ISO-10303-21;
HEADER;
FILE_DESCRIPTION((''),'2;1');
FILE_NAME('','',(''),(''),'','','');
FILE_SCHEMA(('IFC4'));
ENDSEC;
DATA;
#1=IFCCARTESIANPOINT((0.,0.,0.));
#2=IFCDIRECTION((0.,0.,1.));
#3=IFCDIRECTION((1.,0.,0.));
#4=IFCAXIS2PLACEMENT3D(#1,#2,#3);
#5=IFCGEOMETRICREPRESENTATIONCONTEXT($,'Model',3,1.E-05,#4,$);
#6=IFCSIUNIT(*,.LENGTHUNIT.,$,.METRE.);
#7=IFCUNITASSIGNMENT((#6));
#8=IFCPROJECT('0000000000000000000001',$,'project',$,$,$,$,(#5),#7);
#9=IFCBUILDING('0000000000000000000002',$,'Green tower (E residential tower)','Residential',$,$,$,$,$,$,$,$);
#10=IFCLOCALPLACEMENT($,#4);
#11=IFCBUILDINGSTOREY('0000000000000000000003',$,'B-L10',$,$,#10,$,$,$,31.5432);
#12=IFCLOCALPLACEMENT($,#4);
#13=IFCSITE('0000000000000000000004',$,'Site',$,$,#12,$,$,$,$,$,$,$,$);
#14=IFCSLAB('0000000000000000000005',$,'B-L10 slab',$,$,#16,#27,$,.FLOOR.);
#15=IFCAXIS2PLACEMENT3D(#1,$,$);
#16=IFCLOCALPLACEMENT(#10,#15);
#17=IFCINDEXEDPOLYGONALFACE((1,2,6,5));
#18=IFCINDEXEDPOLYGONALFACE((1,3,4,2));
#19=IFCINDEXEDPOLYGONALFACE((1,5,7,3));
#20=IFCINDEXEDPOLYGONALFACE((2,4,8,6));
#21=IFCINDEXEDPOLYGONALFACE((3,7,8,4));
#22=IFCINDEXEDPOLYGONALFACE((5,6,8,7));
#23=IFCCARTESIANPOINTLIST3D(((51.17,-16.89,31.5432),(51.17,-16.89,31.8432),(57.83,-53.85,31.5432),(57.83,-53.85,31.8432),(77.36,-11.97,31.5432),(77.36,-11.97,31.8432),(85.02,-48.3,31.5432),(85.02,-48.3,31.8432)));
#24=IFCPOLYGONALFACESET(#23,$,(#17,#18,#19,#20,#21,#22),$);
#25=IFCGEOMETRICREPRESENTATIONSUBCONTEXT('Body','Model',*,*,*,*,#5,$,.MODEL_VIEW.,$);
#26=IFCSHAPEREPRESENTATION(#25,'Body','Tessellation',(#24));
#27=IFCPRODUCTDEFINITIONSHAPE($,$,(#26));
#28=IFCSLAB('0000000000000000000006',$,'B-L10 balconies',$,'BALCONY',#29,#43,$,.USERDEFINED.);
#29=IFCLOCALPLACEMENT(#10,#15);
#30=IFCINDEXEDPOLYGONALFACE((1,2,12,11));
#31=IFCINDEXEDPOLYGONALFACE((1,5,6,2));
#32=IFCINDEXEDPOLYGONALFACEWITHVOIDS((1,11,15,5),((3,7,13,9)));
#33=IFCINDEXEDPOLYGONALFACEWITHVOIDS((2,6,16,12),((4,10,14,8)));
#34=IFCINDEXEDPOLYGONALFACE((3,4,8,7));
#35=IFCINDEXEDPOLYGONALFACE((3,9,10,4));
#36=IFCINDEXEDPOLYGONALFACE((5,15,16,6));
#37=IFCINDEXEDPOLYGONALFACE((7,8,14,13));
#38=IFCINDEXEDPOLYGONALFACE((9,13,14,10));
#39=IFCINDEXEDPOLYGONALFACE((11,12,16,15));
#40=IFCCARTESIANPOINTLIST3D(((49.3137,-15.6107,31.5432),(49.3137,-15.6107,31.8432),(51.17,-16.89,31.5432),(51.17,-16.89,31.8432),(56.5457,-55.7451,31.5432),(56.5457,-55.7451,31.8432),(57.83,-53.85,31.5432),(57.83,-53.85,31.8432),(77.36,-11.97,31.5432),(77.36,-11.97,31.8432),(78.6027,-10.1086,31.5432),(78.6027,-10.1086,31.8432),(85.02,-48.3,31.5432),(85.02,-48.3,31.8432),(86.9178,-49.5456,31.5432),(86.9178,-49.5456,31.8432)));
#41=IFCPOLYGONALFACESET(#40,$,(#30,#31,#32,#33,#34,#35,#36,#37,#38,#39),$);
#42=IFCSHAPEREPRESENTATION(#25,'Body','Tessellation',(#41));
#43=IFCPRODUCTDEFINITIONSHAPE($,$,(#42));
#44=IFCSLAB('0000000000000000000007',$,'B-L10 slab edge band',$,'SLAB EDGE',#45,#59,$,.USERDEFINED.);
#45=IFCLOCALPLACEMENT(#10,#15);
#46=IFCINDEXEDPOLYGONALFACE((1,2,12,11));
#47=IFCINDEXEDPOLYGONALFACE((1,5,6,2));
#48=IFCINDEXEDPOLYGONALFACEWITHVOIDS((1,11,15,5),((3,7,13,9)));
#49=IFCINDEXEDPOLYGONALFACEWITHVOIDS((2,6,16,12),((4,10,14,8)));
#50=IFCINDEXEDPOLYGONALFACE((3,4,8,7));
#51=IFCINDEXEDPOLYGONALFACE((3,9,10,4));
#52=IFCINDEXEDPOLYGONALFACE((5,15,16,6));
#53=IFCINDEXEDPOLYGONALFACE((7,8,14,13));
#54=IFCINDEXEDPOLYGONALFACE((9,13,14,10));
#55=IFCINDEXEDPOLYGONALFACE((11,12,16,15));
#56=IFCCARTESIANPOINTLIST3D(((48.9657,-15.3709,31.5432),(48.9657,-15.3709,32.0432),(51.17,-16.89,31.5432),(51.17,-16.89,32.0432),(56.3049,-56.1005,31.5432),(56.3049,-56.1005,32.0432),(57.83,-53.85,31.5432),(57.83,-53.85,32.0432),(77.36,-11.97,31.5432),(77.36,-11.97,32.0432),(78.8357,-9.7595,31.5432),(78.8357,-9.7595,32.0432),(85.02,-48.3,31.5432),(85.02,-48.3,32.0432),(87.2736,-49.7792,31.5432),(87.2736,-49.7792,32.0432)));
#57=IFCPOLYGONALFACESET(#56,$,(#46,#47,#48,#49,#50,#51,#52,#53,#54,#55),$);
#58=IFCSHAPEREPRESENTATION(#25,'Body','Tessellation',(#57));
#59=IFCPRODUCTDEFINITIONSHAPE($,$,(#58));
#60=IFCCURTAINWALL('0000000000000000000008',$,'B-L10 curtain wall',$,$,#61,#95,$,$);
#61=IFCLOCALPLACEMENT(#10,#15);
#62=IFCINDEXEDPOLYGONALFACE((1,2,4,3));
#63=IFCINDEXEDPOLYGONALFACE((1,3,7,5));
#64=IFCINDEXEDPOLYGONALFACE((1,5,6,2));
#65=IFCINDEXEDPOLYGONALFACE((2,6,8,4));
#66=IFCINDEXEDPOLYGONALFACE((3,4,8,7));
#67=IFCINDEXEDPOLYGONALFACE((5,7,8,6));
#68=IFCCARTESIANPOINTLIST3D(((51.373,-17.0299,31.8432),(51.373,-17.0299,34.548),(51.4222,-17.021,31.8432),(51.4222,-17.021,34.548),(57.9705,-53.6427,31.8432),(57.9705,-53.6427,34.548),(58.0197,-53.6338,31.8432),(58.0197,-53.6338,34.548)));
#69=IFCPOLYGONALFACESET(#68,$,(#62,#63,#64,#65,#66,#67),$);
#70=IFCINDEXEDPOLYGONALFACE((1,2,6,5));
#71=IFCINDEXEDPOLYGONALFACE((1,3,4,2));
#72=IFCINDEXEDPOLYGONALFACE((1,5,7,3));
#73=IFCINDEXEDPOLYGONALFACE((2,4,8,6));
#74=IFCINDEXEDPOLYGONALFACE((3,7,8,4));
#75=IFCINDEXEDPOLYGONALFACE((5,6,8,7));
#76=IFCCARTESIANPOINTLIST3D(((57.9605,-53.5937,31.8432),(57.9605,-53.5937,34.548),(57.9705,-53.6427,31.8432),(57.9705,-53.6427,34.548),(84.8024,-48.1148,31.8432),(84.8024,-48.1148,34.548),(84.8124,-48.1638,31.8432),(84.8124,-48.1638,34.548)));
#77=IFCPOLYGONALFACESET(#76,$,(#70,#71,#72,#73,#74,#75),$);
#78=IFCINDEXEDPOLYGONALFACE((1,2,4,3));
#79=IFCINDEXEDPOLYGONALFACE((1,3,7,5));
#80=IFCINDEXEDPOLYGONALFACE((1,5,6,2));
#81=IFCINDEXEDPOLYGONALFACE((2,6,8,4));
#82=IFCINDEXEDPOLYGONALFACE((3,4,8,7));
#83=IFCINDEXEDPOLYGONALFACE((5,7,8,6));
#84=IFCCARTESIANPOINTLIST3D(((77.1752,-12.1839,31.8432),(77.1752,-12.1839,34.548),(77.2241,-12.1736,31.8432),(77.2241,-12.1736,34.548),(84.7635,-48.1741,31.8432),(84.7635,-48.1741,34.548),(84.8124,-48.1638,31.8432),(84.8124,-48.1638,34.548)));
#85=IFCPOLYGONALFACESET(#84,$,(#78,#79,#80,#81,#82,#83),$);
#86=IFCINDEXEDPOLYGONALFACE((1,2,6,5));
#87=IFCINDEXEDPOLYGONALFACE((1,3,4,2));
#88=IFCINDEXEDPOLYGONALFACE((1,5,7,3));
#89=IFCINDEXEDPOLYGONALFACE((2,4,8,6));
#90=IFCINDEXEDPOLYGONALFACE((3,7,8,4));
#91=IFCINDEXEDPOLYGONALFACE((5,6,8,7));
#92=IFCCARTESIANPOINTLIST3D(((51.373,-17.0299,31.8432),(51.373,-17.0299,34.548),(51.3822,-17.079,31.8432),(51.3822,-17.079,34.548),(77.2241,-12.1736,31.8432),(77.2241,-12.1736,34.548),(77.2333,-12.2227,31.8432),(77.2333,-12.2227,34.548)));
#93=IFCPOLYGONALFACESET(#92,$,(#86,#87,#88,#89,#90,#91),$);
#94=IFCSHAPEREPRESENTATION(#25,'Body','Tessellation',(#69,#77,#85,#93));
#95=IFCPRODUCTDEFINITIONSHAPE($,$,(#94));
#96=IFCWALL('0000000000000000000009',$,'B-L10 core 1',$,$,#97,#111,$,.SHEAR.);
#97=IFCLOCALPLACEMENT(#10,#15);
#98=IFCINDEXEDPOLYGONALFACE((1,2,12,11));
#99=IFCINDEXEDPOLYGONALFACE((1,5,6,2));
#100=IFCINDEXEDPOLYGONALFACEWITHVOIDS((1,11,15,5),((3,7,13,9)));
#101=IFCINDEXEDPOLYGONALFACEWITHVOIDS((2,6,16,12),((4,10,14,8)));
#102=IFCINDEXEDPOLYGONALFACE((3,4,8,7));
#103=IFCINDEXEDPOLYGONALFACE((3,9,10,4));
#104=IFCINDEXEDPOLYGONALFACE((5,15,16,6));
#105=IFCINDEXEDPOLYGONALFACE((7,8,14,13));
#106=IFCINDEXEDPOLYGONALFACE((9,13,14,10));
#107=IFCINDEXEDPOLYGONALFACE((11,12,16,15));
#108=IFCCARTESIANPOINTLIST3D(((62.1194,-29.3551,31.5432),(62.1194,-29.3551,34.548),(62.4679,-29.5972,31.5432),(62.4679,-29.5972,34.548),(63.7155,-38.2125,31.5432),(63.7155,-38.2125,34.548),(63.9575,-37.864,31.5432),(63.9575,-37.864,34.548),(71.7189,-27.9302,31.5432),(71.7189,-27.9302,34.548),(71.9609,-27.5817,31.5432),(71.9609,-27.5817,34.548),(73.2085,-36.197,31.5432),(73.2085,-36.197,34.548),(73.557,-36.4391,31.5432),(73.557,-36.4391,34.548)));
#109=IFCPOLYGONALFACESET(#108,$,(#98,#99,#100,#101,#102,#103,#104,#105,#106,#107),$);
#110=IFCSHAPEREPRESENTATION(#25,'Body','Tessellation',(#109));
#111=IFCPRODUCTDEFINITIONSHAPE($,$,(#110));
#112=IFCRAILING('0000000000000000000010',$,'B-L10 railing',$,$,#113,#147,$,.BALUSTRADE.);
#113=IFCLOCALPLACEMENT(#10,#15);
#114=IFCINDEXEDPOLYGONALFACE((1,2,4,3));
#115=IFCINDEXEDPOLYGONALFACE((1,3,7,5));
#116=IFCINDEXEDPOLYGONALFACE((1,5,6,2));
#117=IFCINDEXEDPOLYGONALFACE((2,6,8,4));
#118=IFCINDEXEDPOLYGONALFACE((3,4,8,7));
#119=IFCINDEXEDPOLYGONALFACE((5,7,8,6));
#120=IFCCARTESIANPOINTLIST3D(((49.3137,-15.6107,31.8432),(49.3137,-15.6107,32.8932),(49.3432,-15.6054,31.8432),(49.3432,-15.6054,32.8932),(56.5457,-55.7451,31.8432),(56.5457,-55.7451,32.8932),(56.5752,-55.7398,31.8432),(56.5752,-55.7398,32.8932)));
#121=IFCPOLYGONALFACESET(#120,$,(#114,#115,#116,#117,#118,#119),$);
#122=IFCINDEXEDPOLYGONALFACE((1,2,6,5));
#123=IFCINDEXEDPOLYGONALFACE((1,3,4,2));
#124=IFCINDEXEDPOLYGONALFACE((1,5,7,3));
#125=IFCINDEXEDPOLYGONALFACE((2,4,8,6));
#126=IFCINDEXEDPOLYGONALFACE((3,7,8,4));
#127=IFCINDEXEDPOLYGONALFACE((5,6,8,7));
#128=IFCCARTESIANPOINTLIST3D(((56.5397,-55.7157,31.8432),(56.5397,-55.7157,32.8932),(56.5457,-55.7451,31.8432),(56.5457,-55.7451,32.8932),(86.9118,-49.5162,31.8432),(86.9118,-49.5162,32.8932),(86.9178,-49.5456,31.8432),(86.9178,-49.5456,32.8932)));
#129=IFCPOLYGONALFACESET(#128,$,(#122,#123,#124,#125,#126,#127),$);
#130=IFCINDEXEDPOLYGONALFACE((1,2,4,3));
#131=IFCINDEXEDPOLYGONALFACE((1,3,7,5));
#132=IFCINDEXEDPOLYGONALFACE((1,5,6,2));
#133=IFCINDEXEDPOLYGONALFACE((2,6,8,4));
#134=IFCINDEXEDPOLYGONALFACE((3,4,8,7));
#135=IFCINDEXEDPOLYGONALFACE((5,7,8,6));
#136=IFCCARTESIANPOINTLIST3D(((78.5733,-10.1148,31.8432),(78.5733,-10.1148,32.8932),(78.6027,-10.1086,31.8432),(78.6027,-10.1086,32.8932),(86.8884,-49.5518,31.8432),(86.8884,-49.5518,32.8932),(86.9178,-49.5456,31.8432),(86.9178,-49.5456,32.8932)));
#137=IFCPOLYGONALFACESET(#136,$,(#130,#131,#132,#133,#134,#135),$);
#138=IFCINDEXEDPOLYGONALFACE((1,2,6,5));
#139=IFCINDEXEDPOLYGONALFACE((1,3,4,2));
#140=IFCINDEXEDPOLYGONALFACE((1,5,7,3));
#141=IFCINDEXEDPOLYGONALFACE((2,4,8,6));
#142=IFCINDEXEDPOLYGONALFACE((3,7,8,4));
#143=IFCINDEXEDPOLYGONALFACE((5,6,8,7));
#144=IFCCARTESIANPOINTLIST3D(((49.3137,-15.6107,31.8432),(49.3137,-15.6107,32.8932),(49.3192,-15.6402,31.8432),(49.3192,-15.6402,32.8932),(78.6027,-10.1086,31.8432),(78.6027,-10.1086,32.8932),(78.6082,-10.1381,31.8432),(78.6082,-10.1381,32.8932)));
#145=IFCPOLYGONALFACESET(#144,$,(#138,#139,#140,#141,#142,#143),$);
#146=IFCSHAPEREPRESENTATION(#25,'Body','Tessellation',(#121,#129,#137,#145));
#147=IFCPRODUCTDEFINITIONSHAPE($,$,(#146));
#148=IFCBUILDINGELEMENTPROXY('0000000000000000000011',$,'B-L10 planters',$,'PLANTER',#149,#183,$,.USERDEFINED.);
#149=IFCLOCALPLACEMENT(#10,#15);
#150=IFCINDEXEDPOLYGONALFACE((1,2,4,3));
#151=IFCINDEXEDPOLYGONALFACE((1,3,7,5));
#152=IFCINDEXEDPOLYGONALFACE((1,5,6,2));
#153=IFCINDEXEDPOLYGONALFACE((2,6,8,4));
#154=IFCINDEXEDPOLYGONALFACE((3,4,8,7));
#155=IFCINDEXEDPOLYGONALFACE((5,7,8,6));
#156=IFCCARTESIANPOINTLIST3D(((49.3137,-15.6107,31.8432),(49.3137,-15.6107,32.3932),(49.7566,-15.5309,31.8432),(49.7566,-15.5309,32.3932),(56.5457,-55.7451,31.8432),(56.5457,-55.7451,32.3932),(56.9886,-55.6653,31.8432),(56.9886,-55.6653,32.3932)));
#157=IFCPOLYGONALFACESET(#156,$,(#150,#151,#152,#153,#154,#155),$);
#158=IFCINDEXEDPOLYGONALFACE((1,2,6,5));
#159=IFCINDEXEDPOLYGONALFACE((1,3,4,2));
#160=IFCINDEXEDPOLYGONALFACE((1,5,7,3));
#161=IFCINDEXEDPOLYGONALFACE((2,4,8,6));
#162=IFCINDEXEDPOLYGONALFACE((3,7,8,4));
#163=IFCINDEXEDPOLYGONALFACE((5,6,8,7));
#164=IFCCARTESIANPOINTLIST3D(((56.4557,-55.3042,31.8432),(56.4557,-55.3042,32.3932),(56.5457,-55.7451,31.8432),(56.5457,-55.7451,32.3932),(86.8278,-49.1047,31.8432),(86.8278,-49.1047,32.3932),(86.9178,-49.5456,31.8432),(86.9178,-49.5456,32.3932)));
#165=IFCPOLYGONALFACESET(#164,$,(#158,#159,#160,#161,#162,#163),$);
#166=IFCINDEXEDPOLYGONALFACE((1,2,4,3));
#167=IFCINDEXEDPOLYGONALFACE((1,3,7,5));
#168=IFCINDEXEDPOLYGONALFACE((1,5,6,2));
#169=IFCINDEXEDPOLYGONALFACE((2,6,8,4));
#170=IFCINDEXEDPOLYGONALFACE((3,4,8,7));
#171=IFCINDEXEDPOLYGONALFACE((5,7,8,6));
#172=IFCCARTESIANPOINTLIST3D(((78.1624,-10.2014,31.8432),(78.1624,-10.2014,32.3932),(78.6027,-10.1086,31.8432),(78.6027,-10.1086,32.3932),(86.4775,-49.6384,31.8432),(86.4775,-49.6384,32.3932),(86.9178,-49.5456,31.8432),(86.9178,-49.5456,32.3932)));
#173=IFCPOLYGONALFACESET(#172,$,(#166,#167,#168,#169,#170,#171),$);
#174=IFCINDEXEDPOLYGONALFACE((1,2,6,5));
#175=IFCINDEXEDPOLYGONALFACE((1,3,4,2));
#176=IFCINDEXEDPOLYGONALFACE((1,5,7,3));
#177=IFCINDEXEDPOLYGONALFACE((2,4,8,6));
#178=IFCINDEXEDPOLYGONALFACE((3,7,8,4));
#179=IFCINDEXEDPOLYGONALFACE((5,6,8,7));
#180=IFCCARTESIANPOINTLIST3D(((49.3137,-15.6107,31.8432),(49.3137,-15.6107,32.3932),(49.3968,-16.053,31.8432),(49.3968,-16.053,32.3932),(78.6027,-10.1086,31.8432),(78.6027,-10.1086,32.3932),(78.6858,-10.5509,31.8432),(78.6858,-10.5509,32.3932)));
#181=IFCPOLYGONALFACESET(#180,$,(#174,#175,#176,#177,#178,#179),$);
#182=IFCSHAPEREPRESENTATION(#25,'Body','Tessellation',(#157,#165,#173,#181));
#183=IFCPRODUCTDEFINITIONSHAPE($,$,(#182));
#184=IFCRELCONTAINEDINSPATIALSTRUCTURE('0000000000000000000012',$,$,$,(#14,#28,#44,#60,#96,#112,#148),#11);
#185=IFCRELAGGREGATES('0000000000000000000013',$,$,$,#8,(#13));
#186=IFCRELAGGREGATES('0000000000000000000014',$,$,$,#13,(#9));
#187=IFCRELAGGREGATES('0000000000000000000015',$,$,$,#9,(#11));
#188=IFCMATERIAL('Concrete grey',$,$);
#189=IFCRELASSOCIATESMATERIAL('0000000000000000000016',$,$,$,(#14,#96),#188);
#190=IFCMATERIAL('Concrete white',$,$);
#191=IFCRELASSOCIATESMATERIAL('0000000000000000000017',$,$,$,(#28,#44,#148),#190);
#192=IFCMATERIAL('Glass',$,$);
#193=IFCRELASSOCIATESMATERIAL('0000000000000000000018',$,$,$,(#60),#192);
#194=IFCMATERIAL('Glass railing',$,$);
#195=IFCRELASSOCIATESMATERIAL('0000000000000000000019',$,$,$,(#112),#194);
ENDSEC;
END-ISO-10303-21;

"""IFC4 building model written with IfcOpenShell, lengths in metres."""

from ifc_helpers import new_model, si_unit, frame, origin_with_axes, place, context, subcontext, project, spatial, polyline, outline, extrude, material, element, save


model = new_model("IFC4")

# Units and contexts
model_context = context("Model", 3, precision=1e-05, world=origin_with_axes())
body_context = subcontext(model_context, "Body", "Model", "MODEL_VIEW")
ifc_project = project(units=[si_unit("LENGTHUNIT", "METRE")], contexts=[model_context])

# Site, building, storey
site_placement = place(None, origin_with_axes())
site = spatial("IfcSite", under=ifc_project, at=site_placement, Name="Site")
building = spatial("IfcBuilding", under=site, Name="Green tower (E residential tower)", Description="Residential")
storey_placement = place(None, origin_with_axes())
storey = spatial("IfcBuildingStorey", under=building, at=storey_placement, Name="B-L10", Elevation=31.5432)

# Slabs
ifc_material_1 = material(Name="Concrete grey")
slab_1_placement = place(storey_placement, origin_with_axes())
element("IfcSlab", 1, at=slab_1_placement, inside=storey, material=ifc_material_1, Name="B-L10 slab", PredefinedType="FLOOR", context=body_context, shape_type="SweptSolid", body=[
    extrude(outline(polyline([(51.17, -16.89), (57.83, -53.85), (85.02, -48.3), (77.36, -11.97), (51.17, -16.89)])), frame((0.0, 0.0, 31.5432), z_axis=(0.0, 0.0, 1.0), x_axis=(1.0, 0.0, 0.0)), (0.0, 0.0, 1.0), 0.3),
])
ifc_material_2 = material(Name="Concrete white")
slab_2_placement = place(storey_placement, origin_with_axes())
element("IfcSlab", 2, at=slab_2_placement, inside=storey, material=ifc_material_2, Name="B-L10 balconies", ObjectType="BALCONY", PredefinedType="USERDEFINED", context=body_context, shape_type="SweptSolid", body=[
    extrude(outline(polyline([(49.3137, -15.6107), (56.5457, -55.7451), (86.9178, -49.5456), (78.6027, -10.1086), (49.3137, -15.6107)]), holes=[polyline([(51.17, -16.89), (57.83, -53.85), (85.02, -48.3), (77.36, -11.97), (51.17, -16.89)])]), frame((0.0, 0.0, 31.5432), z_axis=(0.0, 0.0, 1.0), x_axis=(1.0, 0.0, 0.0)), (0.0, 0.0, 1.0), 0.3),
])
slab_3_placement = place(storey_placement, origin_with_axes())
element("IfcSlab", 3, at=slab_3_placement, inside=storey, material=ifc_material_2, Name="B-L10 slab edge band", ObjectType="SLAB EDGE", PredefinedType="USERDEFINED", context=body_context, shape_type="SweptSolid", body=[
    extrude(outline(polyline([(48.9657, -15.3709), (56.3049, -56.1005), (87.2736, -49.7792), (78.8357, -9.7595), (48.9657, -15.3709)]), holes=[polyline([(51.17, -16.89), (57.83, -53.85), (85.02, -48.3), (77.36, -11.97), (51.17, -16.89)])]), frame((0.0, 0.0, 31.5432), z_axis=(0.0, 0.0, 1.0), x_axis=(1.0, 0.0, 0.0)), (0.0, 0.0, 1.0), 0.5),
])

# Curtain wall
ifc_material_3 = material(Name="Glass")
curtain_wall_placement = place(storey_placement, origin_with_axes())
element("IfcCurtainWall", 4, at=curtain_wall_placement, inside=storey, material=ifc_material_3, Name="B-L10 curtain wall", context=body_context, shape_type="SweptSolid", body=[
    extrude(outline(polyline([(51.373, -17.0299), (57.9705, -53.6427), (58.0197, -53.6338), (51.4222, -17.021), (51.373, -17.0299)])), frame((0.0, 0.0, 31.8432), z_axis=(0.0, 0.0, 1.0), x_axis=(1.0, 0.0, 0.0)), (0.0, 0.0, 1.0), 2.7048),
    extrude(outline(polyline([(57.9705, -53.6427), (84.8124, -48.1638), (84.8024, -48.1148), (57.9605, -53.5937), (57.9705, -53.6427)])), frame((0.0, 0.0, 31.8432), z_axis=(0.0, 0.0, 1.0), x_axis=(1.0, 0.0, 0.0)), (0.0, 0.0, 1.0), 2.7048),
    extrude(outline(polyline([(84.8124, -48.1638), (77.2241, -12.1736), (77.1752, -12.1839), (84.7635, -48.1741), (84.8124, -48.1638)])), frame((0.0, 0.0, 31.8432), z_axis=(0.0, 0.0, 1.0), x_axis=(1.0, 0.0, 0.0)), (0.0, 0.0, 1.0), 2.7048),
    extrude(outline(polyline([(77.2241, -12.1736), (51.373, -17.0299), (51.3822, -17.079), (77.2333, -12.2227), (77.2241, -12.1736)])), frame((0.0, 0.0, 31.8432), z_axis=(0.0, 0.0, 1.0), x_axis=(1.0, 0.0, 0.0)), (0.0, 0.0, 1.0), 2.7048),
])

# Wall
wall_placement = place(storey_placement, origin_with_axes())
element("IfcWall", 5, at=wall_placement, inside=storey, material=ifc_material_1, Name="B-L10 core 1", PredefinedType="SHEAR", context=body_context, shape_type="SweptSolid", body=[
    extrude(outline(polyline([(62.1194, -29.3551), (63.7155, -38.2125), (73.557, -36.4391), (71.9609, -27.5817), (62.1194, -29.3551)]), holes=[polyline([(62.4679, -29.5972), (63.9575, -37.864), (73.2085, -36.197), (71.7189, -27.9302), (62.4679, -29.5972)])]), frame((0.0, 0.0, 31.5432), z_axis=(0.0, 0.0, 1.0), x_axis=(1.0, 0.0, 0.0)), (0.0, 0.0, 1.0), 3.0048),
])

# Railing
ifc_material_4 = material(Name="Glass railing")
railing_placement = place(storey_placement, origin_with_axes())
element("IfcRailing", 6, at=railing_placement, inside=storey, material=ifc_material_4, Name="B-L10 railing", PredefinedType="BALUSTRADE", context=body_context, shape_type="SweptSolid", body=[
    extrude(outline(polyline([(49.3137, -15.6107), (56.5457, -55.7451), (56.5752, -55.7398), (49.3432, -15.6054), (49.3137, -15.6107)])), frame((0.0, 0.0, 31.8432), z_axis=(0.0, 0.0, 1.0), x_axis=(1.0, 0.0, 0.0)), (0.0, 0.0, 1.0), 1.05),
    extrude(outline(polyline([(56.5457, -55.7451), (86.9178, -49.5456), (86.9118, -49.5162), (56.5397, -55.7157), (56.5457, -55.7451)])), frame((0.0, 0.0, 31.8432), z_axis=(0.0, 0.0, 1.0), x_axis=(1.0, 0.0, 0.0)), (0.0, 0.0, 1.0), 1.05),
    extrude(outline(polyline([(86.9178, -49.5456), (78.6027, -10.1086), (78.5733, -10.1148), (86.8884, -49.5518), (86.9178, -49.5456)])), frame((0.0, 0.0, 31.8432), z_axis=(0.0, 0.0, 1.0), x_axis=(1.0, 0.0, 0.0)), (0.0, 0.0, 1.0), 1.05),
    extrude(outline(polyline([(78.6027, -10.1086), (49.3137, -15.6107), (49.3192, -15.6402), (78.6082, -10.1381), (78.6027, -10.1086)])), frame((0.0, 0.0, 31.8432), z_axis=(0.0, 0.0, 1.0), x_axis=(1.0, 0.0, 0.0)), (0.0, 0.0, 1.0), 1.05),
])

# Building element proxy
proxy_1_placement = place(storey_placement, origin_with_axes())
element("IfcBuildingElementProxy", 7, at=proxy_1_placement, inside=storey, material=ifc_material_2, Name="B-L10 planters", ObjectType="PLANTER", PredefinedType="USERDEFINED", context=body_context, shape_type="SweptSolid", body=[
    extrude(outline(polyline([(49.3137, -15.6107), (56.5457, -55.7451), (56.9886, -55.6653), (49.7566, -15.5309), (49.3137, -15.6107)])), frame((0.0, 0.0, 31.8432), z_axis=(0.0, 0.0, 1.0), x_axis=(1.0, 0.0, 0.0)), (0.0, 0.0, 1.0), 0.55),
    extrude(outline(polyline([(56.5457, -55.7451), (86.9178, -49.5456), (86.8278, -49.1047), (56.4557, -55.3042), (56.5457, -55.7451)])), frame((0.0, 0.0, 31.8432), z_axis=(0.0, 0.0, 1.0), x_axis=(1.0, 0.0, 0.0)), (0.0, 0.0, 1.0), 0.55),
    extrude(outline(polyline([(86.9178, -49.5456), (78.6027, -10.1086), (78.1624, -10.2014), (86.4775, -49.6384), (86.9178, -49.5456)])), frame((0.0, 0.0, 31.8432), z_axis=(0.0, 0.0, 1.0), x_axis=(1.0, 0.0, 0.0)), (0.0, 0.0, 1.0), 0.55),
    extrude(outline(polyline([(78.6027, -10.1086), (49.3137, -15.6107), (49.3968, -16.053), (78.6858, -10.5509), (78.6027, -10.1086)])), frame((0.0, 0.0, 31.8432), z_axis=(0.0, 0.0, 1.0), x_axis=(1.0, 0.0, 0.0)), (0.0, 0.0, 1.0), 0.55),
])

save(model, "model.ifc")
